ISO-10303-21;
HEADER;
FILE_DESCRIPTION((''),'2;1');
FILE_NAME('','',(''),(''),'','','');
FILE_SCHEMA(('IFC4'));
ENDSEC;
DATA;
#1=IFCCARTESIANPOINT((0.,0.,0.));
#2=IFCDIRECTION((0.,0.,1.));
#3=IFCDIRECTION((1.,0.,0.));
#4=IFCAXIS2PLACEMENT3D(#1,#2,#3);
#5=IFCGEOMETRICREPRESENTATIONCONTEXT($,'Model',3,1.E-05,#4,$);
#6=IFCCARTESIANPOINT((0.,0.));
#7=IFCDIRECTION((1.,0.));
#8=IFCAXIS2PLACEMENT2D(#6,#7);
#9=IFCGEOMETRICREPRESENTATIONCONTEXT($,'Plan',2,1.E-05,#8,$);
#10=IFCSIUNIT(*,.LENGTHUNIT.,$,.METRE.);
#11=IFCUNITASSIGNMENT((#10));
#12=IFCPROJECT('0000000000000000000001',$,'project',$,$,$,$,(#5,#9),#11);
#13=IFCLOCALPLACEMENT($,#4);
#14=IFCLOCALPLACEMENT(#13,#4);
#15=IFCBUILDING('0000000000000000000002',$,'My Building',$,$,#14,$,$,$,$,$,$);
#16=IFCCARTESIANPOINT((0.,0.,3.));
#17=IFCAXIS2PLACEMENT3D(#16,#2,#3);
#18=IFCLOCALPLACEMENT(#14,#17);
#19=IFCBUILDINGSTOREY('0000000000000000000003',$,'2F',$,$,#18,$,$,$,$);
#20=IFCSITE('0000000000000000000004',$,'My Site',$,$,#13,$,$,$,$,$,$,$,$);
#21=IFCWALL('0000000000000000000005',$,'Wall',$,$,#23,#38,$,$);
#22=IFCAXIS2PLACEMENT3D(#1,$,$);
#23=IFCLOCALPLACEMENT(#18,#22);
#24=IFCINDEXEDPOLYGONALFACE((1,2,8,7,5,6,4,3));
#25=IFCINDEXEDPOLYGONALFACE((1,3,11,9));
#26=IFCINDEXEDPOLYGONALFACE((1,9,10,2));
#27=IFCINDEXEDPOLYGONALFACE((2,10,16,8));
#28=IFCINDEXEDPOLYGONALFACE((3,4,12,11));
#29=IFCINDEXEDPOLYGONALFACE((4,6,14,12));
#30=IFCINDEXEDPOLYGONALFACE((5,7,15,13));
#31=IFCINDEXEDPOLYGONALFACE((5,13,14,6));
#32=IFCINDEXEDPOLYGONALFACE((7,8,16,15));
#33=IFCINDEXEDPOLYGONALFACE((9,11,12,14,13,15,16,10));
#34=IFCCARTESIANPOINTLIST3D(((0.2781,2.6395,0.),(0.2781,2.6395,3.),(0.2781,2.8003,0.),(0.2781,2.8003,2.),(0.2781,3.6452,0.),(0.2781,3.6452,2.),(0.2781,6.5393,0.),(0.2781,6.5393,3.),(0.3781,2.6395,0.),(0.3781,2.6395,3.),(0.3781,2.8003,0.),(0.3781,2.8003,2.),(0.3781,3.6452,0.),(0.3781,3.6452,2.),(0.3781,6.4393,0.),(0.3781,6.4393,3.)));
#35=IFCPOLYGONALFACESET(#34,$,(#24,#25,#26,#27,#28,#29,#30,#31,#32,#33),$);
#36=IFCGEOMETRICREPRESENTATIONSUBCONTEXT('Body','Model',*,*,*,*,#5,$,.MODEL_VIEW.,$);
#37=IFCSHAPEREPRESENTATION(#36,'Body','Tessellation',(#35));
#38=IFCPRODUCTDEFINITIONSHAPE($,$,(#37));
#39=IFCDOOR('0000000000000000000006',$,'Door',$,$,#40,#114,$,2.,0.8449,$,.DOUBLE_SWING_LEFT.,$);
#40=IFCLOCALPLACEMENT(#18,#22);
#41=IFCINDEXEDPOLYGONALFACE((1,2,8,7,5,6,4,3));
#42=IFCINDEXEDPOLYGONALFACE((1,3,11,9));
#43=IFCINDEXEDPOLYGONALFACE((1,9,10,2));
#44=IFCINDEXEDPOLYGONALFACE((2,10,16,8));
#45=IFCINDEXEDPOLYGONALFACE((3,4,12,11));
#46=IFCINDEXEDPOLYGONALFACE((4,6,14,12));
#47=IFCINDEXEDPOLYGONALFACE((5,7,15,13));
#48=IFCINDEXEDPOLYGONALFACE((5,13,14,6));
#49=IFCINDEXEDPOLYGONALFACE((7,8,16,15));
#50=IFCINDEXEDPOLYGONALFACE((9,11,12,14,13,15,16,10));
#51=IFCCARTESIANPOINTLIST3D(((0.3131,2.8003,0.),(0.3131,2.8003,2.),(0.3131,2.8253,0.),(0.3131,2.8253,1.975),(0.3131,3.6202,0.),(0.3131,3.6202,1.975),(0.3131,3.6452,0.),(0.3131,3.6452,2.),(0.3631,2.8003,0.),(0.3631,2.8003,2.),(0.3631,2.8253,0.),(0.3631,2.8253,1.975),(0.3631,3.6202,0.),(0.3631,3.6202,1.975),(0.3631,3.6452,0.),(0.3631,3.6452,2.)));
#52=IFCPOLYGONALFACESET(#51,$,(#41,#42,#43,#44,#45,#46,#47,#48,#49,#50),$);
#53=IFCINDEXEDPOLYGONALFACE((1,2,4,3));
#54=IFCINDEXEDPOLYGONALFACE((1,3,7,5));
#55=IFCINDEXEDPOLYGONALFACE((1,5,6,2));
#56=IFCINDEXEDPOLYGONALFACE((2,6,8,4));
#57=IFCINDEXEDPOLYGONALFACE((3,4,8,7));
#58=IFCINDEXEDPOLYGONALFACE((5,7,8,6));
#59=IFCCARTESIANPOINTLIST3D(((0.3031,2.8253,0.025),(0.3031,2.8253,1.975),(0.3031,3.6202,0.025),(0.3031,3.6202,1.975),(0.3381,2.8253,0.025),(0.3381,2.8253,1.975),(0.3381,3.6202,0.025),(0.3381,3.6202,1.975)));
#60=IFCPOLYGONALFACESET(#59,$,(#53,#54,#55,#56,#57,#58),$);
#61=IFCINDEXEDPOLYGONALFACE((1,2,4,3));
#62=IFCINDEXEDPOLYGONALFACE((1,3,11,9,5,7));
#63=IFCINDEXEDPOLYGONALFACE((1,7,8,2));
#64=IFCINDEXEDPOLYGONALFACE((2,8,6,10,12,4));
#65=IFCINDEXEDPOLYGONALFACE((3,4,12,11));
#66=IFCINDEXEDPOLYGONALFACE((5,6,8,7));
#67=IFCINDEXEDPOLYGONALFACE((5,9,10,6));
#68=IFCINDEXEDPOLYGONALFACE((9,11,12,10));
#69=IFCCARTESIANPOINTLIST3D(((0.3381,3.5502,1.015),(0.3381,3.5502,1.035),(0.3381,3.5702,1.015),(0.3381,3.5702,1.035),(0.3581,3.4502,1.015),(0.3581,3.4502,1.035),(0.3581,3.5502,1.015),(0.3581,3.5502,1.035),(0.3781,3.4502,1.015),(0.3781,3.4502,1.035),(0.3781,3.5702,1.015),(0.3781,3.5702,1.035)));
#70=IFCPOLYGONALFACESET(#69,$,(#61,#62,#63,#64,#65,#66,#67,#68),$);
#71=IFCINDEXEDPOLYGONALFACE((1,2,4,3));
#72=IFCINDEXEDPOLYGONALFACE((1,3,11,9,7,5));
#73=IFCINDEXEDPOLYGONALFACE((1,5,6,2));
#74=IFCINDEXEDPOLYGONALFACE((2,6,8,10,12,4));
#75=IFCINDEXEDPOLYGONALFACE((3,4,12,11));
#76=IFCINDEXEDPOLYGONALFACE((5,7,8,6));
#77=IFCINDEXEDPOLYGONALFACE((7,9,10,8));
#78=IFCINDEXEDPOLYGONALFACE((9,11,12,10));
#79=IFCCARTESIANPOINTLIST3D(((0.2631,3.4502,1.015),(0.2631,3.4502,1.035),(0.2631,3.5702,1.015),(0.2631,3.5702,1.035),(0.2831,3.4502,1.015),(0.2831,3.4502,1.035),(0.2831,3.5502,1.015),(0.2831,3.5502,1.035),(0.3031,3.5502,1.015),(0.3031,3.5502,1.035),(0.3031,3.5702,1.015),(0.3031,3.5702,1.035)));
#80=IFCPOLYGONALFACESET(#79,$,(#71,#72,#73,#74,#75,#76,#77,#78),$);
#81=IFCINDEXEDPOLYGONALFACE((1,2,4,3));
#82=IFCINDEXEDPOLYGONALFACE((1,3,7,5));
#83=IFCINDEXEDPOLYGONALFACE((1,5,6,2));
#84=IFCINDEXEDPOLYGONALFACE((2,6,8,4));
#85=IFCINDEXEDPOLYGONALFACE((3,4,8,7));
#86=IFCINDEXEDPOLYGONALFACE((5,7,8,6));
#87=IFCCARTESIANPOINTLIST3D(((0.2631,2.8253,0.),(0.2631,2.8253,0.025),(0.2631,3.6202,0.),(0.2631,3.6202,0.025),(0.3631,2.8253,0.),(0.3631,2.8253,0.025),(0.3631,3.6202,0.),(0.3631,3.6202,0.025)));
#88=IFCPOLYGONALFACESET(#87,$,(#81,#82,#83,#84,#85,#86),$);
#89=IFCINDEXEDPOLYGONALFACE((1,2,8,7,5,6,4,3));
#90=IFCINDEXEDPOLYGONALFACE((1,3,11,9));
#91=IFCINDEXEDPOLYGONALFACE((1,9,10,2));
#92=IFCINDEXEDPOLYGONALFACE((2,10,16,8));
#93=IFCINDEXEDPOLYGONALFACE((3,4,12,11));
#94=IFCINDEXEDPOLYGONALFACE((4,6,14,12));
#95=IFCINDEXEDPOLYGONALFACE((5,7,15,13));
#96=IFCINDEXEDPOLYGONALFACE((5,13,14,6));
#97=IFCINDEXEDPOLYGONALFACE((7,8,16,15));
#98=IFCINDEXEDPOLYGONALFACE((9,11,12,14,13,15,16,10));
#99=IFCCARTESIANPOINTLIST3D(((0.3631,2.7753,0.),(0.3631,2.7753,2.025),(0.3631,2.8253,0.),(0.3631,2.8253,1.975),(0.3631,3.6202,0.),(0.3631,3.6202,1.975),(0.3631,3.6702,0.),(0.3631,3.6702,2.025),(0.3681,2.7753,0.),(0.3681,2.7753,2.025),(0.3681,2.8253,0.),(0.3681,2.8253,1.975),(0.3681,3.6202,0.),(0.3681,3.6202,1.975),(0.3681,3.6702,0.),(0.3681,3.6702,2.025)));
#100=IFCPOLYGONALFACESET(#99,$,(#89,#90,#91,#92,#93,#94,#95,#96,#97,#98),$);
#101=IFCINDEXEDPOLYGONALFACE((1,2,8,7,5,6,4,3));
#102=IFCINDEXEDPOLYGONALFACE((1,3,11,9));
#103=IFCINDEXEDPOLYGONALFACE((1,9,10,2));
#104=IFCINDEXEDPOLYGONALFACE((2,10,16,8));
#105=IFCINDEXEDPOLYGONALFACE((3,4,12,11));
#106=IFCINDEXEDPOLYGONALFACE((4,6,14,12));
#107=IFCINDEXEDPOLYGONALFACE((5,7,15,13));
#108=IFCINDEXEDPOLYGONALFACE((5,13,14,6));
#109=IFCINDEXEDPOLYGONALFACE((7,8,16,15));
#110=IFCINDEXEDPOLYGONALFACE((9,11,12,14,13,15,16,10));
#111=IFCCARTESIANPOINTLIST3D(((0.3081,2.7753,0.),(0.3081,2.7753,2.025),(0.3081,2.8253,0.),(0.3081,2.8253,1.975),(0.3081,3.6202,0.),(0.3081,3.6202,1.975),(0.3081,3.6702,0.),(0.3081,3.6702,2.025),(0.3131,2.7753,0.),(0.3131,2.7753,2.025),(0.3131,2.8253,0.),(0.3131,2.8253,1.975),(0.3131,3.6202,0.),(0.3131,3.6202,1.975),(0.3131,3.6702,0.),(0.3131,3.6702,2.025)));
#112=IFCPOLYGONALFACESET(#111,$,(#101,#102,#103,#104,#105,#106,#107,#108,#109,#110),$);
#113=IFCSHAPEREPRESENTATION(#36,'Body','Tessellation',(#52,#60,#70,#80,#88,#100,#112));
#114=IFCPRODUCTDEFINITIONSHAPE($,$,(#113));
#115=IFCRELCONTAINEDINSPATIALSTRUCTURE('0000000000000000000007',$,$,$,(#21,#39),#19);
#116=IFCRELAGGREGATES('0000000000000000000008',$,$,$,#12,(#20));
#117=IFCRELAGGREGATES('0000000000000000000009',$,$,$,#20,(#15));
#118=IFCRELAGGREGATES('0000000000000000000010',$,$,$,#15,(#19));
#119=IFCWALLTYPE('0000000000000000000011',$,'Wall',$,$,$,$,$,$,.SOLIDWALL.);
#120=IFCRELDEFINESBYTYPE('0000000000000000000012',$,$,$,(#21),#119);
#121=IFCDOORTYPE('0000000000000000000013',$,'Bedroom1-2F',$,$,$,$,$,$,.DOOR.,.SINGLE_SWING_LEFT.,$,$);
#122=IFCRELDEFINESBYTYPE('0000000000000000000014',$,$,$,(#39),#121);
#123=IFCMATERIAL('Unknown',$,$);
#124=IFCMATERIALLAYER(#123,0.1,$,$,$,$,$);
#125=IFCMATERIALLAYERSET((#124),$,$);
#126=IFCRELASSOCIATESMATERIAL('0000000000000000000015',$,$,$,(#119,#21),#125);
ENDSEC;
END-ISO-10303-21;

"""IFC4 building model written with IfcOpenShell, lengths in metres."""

from ifc_helpers import new_model, entity, si_unit, frame, origin_with_axes, origin_2d_with_axis, place, context, subcontext, project, spatial, line, indexed_curve, outline, extrude, shape, source, transform, mapped, material, layer, layer_set, layer_usage, type_object, type_shapes, element, fill, save


model = new_model("IFC4")

# Units and contexts
model_context = context("Model", 3, precision=1e-05, world=origin_with_axes())
plan_context = context("Plan", 2, precision=1e-05, world=origin_2d_with_axis())
body_context_1 = subcontext(model_context, "Body", "Model", "MODEL_VIEW")
body_context_2 = subcontext(plan_context, "Body", "Plan", "PLAN_VIEW")
ifc_project = project(units=[si_unit("LENGTHUNIT", "METRE")], contexts=[model_context, plan_context])

# Site, building, storey
site_placement = place(None, origin_with_axes())
site = spatial("IfcSite", under=ifc_project, at=site_placement, Name="My Site")
building_placement = place(site_placement, origin_with_axes())
building = spatial("IfcBuilding", under=site, at=building_placement, Name="My Building")
storey_placement = place(building_placement, frame((0.0, 0.0, 3.0), z_axis=(0.0, 0.0, 1.0), x_axis=(1.0, 0.0, 0.0)))
storey = spatial("IfcBuildingStorey", under=building, at=storey_placement, Name="2F")

# Shared definitions
ifc_material = material(Name="Unknown")

# Shared definitions
ifc_layer = layer(ifc_material, 0.1)
ifc_layer_set = layer_set([ifc_layer])
wall_type = type_object("IfcWallType", Name="Wall", PredefinedType="SOLIDWALL", material=ifc_layer_set)

# Wall, opening, door
ifc_layer_usage_1 = layer_usage(ifc_layer_set, "AXIS2", "POSITIVE", 0.0)
wall_1_placement = place(storey_placement, frame((0.2781, 6.5393, 0.0), z_axis=(0.0, 0.0, 1.0), x_axis=(0.0, -1.0, 0.0)))
wall_1 = element("IfcWall", 1, at=wall_1_placement, inside=storey, type_object=wall_type, material=ifc_layer_usage_1, Name="Wall", context=body_context_1, shape_type="SweptSolid", body=[
    extrude(outline(indexed_curve([(0.0, 0.0), (0.1, 0.1), (3.8998, 0.1), (3.8998, 0.0)], segments=[line(1, 2, 3, 4, 1)])), origin_with_axes(), (0.0, 0.0, 1.0), 3.0),
])
shared_shape_1 = source(origin_with_axes(), body_context_1, "Body", "SweptSolid", [
    extrude(outline(indexed_curve([(0.0, 0.0), (0.8449, 0.0), (0.8449, 2.0), (0.0, 2.0)], segments=[line(1, 2, 3, 4, 1)])), frame((0.0, -0.6, 0.0), z_axis=(0.0, -1.0, 0.0), x_axis=(1.0, 0.0, 0.0)), (0.0, 0.0, -1.0), 1.2),
])
opening_1_placement = place(wall_1_placement, frame((3.739, 0.085, 0.0), z_axis=(0.0, 0.0, 1.0), x_axis=(-1.0, 0.0, 0.0)))
opening_1 = element("IfcOpeningElement", 2, at=opening_1_placement, cuts=wall_1, PredefinedType="OPENING", context=body_context_1, shape_type="MappedRepresentation", body=[
    mapped(shared_shape_1, transform((0.0, 0.0, 0.0), x_axis=(1.0, 0.0, 0.0), y_axis=(0.0, 1.0, 0.0), z_axis=(0.0, 0.0, 1.0), scale=1.0)),
])
door_type_1 = type_object("IfcDoorType", Name="Bedroom1-2F", OperationType="SINGLE_SWING_LEFT", PredefinedType="DOOR")
shared_shape_2 = source(origin_with_axes(), body_context_1, "Body", "SweptSolid", [
    extrude(outline(indexed_curve([(0.0, 0.0), (0.0, 2.0), (0.8449, 2.0), (0.8449, 0.0), (0.8199, 0.0), (0.8199, 1.975), (0.025, 1.975), (0.025, 0.0)], segments=[line(1, 2, 3, 4, 5, 6, 7, 8, 1)])), frame((0.0, 0.0, 0.0), z_axis=(0.0, -1.0, 0.0), x_axis=(1.0, 0.0, 0.0)), (0.0, 0.0, -1.0), 0.05),
    extrude(outline(indexed_curve([(0.0, 0.0), (0.7949, 0.0), (0.7949, 0.035), (0.0, 0.035)], segments=[line(1, 2, 3, 4, 1)])), frame((0.025, 0.025, 0.025), z_axis=(0.0, 0.0, 1.0), x_axis=(1.0, 0.0, 0.0)), (0.0, 0.0, 1.0), 1.95),
    extrude(outline(indexed_curve([(0.0, 0.0), (0.0, -0.04), (-0.12, -0.04), (-0.12, -0.02), (-0.02, -0.02), (-0.02, 0.0)], segments=[line(1, 2, 3, 4, 5, 6, 1)])), frame((0.7699, 0.025, 1.015), z_axis=(0.0, 0.0, 1.0), x_axis=(1.0, 0.0, 0.0)), (0.0, 0.0, 1.0), 0.02),
    extrude(outline(indexed_curve([(0.0, 0.0), (0.0, 0.04), (-0.12, 0.04), (-0.12, 0.02), (-0.02, 0.02), (-0.02, 0.0)], segments=[line(1, 2, 3, 4, 5, 6, 1)])), frame((0.7699, 0.06, 1.015), z_axis=(0.0, 0.0, 1.0), x_axis=(1.0, 0.0, 0.0)), (0.0, 0.0, 1.0), 0.02),
    extrude(outline(indexed_curve([(0.0, 0.0), (0.7949, 0.0), (0.7949, 0.1), (0.0, 0.1)], segments=[line(1, 2, 3, 4, 1)])), frame((0.025, 0.0, 0.0), z_axis=(0.0, 0.0, 1.0), x_axis=(1.0, 0.0, 0.0)), (0.0, 0.0, 1.0), 0.025),
    extrude(outline(indexed_curve([(0.0, 0.0), (0.0, 2.025), (0.8949, 2.025), (0.8949, 0.0), (0.8449, 0.0), (0.8449, 1.975), (0.05, 1.975), (0.05, 0.0)], segments=[line(1, 2, 3, 4, 5, 6, 7, 8, 1)])), frame((-0.025, -0.005, 0.0), z_axis=(0.0, -1.0, 0.0), x_axis=(1.0, 0.0, 0.0)), (0.0, 0.0, -1.0), 0.005),
    extrude(outline(indexed_curve([(0.0, 0.0), (0.0, 2.025), (0.8949, 2.025), (0.8949, 0.0), (0.8449, 0.0), (0.8449, 1.975), (0.05, 1.975), (0.05, 0.0)], segments=[line(1, 2, 3, 4, 5, 6, 7, 8, 1)])), frame((-0.025, 0.05, 0.0), z_axis=(0.0, -1.0, 0.0), x_axis=(1.0, 0.0, 0.0)), (0.0, 0.0, -1.0), 0.005),
])
shared_shape_3 = source(origin_with_axes(), body_context_2, "Body", "Curve2D", [
    entity("IfcIndexedPolyCurve", entity("IfcCartesianPointList2D", [[0.0, 0.0], [0.025, 0.0], [0.025, 0.05], [0.0, 0.05]]), [entity("IfcLineIndex", [1, 2, 3, 4, 1])]),
    entity("IfcIndexedPolyCurve", entity("IfcCartesianPointList2D", [[0.8449, 0.0], [0.8199, 0.0], [0.8199, 0.05], [0.8449, 0.05]]), [entity("IfcLineIndex", [1, 2, 3, 4, 1])]),
    entity("IfcIndexedPolyCurve", entity("IfcCartesianPointList2D", [[0.025, 0.05], [0.025, -0.7449], [0.06, -0.7449]])),
    entity("IfcTrimmedCurve", entity("IfcEllipse", entity("IfcAxis2Placement2D", entity("IfcCartesianPoint", [0.06, 0.05]), entity("IfcDirection", [1.0, 0.0])), 0.7599, 0.7949), [entity("IfcCartesianPoint", [0.06, -0.7449])], [entity("IfcCartesianPoint", [0.06, 0.8449])], True, "CARTESIAN"),
    entity("IfcIndexedPolyCurve", entity("IfcCartesianPointList2D", [[0.025, 0.05], [0.06, 0.05], [0.06, 0.8449], [0.025, 0.8449]]), [entity("IfcLineIndex", [1, 2, 3, 4, 1])]),
])
type_shapes(door_type_1, [shared_shape_2, shared_shape_3])
door_1_placement = place(opening_1_placement, frame((0.0, 0.0, 0.0), z_axis=(0.0, 0.0, 1.0), x_axis=(1.0, 0.0, 0.0)))
door_1 = element("IfcDoor", 3, at=door_1_placement, inside=storey, type_object=door_type_1, Name="Door", OperationType="DOUBLE_SWING_LEFT", OverallHeight=2.0, OverallWidth=0.8449, shapes=[
    shape(body_context_1, "Body", "MappedRepresentation", [mapped(shared_shape_2, transform((0.0, 0.0, 0.0), x_axis=(1.0, 0.0, 0.0), y_axis=(0.0, 1.0, 0.0), z_axis=(0.0, 0.0, 1.0), scale=1.0))]),
    shape(body_context_2, "Body", "MappedRepresentation", [mapped(shared_shape_3, transform((0.0, 0.0, 0.0), x_axis=(1.0, 0.0, 0.0), y_axis=(0.0, 1.0, 0.0), z_axis=(0.0, 0.0, 1.0), scale=1.0))]),
])
fill(opening_1, door_1)

save(model, "model.ifc")
